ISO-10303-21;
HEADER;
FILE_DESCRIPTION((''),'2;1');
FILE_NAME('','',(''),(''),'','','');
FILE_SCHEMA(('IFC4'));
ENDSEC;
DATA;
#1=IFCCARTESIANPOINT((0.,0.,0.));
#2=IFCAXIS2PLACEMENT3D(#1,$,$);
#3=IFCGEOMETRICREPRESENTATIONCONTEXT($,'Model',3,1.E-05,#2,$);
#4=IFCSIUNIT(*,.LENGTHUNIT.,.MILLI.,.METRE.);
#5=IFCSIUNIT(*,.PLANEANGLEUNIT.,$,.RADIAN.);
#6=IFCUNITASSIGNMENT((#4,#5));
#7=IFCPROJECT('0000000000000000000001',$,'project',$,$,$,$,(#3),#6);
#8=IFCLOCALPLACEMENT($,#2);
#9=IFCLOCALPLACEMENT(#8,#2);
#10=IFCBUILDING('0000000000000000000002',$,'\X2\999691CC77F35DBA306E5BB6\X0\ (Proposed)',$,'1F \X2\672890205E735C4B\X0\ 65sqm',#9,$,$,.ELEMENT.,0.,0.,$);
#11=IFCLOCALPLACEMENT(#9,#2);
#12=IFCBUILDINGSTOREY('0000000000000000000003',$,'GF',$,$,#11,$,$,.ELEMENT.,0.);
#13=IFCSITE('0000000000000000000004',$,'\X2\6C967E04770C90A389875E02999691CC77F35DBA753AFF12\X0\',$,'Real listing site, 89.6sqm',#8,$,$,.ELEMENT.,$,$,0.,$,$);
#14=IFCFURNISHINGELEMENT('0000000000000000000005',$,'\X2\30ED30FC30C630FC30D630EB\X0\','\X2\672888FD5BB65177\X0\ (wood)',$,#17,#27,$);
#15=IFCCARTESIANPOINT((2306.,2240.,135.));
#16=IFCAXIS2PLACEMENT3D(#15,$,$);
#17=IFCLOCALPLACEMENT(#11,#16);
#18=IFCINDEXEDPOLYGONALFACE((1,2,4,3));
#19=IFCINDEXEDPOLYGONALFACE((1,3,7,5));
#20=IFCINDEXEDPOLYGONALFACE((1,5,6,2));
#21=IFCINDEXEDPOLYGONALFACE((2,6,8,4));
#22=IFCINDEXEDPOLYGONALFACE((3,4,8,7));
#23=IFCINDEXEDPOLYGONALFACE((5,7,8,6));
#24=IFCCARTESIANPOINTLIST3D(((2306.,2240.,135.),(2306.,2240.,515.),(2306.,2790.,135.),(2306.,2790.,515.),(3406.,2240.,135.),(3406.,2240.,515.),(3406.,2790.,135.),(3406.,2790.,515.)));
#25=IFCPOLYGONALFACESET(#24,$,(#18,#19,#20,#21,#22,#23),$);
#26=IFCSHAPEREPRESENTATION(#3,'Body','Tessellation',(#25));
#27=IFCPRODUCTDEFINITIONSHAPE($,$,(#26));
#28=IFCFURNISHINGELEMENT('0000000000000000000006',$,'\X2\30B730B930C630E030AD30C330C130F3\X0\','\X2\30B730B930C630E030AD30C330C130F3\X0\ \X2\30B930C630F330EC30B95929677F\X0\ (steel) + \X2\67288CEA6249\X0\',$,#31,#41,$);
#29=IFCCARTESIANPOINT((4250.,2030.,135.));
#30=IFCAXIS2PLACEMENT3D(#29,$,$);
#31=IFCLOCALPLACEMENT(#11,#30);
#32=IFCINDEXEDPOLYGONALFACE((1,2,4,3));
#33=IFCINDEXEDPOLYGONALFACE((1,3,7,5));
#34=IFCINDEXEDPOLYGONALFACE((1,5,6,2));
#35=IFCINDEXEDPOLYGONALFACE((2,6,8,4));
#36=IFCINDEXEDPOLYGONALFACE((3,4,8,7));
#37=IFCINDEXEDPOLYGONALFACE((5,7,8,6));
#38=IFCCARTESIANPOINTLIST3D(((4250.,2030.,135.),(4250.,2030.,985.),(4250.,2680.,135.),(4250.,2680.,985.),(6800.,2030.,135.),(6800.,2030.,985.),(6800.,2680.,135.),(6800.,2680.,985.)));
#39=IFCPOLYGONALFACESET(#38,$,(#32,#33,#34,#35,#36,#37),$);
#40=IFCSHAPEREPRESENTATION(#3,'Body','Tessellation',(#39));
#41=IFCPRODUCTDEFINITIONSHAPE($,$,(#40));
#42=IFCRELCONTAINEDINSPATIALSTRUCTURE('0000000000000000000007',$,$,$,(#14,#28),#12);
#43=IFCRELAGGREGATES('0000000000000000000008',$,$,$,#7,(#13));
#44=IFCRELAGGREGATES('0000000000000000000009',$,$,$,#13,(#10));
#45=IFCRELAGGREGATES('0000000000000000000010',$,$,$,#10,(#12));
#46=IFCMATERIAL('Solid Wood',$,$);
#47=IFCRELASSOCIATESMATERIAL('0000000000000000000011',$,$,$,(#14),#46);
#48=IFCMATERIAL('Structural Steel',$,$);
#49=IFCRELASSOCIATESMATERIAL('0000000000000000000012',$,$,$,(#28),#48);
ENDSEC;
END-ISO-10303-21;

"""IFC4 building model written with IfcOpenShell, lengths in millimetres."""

from ifc_helpers import new_model, si_unit, frame, frame_2d, origin, place, context, project, spatial, rectangle, extrude, material, element, save


model = new_model("IFC4")

# Units and contexts
model_context = context("Model", 3, precision=1e-05, world=origin())
ifc_project = project(units=[si_unit("LENGTHUNIT", "METRE", prefix="MILLI"), si_unit("PLANEANGLEUNIT", "RADIAN")], contexts=[model_context])

# Site, building, storey
site_placement = place(None, origin())
site = spatial("IfcSite", under=ifc_project, at=site_placement, Name="沖縄県那覇市首里石嶺町２", ObjectType="Real listing site, 89.6sqm", CompositionType="ELEMENT", RefElevation=0.0)
building_placement = place(site_placement, origin())
building = spatial("IfcBuilding", under=site, at=building_placement, Name="首里石嶺の家 (Proposed)", ObjectType="1F 木造平屋 65sqm", CompositionType="ELEMENT", ElevationOfRefHeight=0.0, ElevationOfTerrain=0.0)
storey_placement = place(building_placement, origin())
storey = spatial("IfcBuildingStorey", under=building, at=storey_placement, Name="GF", CompositionType="ELEMENT", Elevation=0.0)

# Shared definitions
ifc_material_1 = material(Name="Solid Wood")

# Furnishing elements
furnishing_1_placement = place(storey_placement, frame((2306.0, 2240.0, 135.0)))
element("IfcFurnishingElement", 1, at=furnishing_1_placement, inside=storey, material=ifc_material_1, Name="ローテーブル", Description="木製家具 (wood)", context=model_context, shape_type="SweptSolid", body=[
    extrude(rectangle(XDim=1100.0, YDim=550.0, at=frame_2d((550.0, 275.0))), frame((2306.0, 2240.0, 135.0)), (0.0, 0.0, 1.0), 380.0),
])
ifc_material_2 = material(Name="Structural Steel")
furnishing_2_placement = place(storey_placement, frame((4250.0, 2030.0, 135.0)))
element("IfcFurnishingElement", 2, at=furnishing_2_placement, inside=storey, material=ifc_material_2, Name="システムキッチン", Description="システムキッチン ステンレス天板 (steel) + 木質扉", context=model_context, shape_type="SweptSolid", body=[
    extrude(rectangle(XDim=2550.0, YDim=650.0, at=frame_2d((1275.0, 325.0))), frame((4250.0, 2030.0, 135.0)), (0.0, 0.0, 1.0), 850.0),
])

save(model, "model.ifc")
